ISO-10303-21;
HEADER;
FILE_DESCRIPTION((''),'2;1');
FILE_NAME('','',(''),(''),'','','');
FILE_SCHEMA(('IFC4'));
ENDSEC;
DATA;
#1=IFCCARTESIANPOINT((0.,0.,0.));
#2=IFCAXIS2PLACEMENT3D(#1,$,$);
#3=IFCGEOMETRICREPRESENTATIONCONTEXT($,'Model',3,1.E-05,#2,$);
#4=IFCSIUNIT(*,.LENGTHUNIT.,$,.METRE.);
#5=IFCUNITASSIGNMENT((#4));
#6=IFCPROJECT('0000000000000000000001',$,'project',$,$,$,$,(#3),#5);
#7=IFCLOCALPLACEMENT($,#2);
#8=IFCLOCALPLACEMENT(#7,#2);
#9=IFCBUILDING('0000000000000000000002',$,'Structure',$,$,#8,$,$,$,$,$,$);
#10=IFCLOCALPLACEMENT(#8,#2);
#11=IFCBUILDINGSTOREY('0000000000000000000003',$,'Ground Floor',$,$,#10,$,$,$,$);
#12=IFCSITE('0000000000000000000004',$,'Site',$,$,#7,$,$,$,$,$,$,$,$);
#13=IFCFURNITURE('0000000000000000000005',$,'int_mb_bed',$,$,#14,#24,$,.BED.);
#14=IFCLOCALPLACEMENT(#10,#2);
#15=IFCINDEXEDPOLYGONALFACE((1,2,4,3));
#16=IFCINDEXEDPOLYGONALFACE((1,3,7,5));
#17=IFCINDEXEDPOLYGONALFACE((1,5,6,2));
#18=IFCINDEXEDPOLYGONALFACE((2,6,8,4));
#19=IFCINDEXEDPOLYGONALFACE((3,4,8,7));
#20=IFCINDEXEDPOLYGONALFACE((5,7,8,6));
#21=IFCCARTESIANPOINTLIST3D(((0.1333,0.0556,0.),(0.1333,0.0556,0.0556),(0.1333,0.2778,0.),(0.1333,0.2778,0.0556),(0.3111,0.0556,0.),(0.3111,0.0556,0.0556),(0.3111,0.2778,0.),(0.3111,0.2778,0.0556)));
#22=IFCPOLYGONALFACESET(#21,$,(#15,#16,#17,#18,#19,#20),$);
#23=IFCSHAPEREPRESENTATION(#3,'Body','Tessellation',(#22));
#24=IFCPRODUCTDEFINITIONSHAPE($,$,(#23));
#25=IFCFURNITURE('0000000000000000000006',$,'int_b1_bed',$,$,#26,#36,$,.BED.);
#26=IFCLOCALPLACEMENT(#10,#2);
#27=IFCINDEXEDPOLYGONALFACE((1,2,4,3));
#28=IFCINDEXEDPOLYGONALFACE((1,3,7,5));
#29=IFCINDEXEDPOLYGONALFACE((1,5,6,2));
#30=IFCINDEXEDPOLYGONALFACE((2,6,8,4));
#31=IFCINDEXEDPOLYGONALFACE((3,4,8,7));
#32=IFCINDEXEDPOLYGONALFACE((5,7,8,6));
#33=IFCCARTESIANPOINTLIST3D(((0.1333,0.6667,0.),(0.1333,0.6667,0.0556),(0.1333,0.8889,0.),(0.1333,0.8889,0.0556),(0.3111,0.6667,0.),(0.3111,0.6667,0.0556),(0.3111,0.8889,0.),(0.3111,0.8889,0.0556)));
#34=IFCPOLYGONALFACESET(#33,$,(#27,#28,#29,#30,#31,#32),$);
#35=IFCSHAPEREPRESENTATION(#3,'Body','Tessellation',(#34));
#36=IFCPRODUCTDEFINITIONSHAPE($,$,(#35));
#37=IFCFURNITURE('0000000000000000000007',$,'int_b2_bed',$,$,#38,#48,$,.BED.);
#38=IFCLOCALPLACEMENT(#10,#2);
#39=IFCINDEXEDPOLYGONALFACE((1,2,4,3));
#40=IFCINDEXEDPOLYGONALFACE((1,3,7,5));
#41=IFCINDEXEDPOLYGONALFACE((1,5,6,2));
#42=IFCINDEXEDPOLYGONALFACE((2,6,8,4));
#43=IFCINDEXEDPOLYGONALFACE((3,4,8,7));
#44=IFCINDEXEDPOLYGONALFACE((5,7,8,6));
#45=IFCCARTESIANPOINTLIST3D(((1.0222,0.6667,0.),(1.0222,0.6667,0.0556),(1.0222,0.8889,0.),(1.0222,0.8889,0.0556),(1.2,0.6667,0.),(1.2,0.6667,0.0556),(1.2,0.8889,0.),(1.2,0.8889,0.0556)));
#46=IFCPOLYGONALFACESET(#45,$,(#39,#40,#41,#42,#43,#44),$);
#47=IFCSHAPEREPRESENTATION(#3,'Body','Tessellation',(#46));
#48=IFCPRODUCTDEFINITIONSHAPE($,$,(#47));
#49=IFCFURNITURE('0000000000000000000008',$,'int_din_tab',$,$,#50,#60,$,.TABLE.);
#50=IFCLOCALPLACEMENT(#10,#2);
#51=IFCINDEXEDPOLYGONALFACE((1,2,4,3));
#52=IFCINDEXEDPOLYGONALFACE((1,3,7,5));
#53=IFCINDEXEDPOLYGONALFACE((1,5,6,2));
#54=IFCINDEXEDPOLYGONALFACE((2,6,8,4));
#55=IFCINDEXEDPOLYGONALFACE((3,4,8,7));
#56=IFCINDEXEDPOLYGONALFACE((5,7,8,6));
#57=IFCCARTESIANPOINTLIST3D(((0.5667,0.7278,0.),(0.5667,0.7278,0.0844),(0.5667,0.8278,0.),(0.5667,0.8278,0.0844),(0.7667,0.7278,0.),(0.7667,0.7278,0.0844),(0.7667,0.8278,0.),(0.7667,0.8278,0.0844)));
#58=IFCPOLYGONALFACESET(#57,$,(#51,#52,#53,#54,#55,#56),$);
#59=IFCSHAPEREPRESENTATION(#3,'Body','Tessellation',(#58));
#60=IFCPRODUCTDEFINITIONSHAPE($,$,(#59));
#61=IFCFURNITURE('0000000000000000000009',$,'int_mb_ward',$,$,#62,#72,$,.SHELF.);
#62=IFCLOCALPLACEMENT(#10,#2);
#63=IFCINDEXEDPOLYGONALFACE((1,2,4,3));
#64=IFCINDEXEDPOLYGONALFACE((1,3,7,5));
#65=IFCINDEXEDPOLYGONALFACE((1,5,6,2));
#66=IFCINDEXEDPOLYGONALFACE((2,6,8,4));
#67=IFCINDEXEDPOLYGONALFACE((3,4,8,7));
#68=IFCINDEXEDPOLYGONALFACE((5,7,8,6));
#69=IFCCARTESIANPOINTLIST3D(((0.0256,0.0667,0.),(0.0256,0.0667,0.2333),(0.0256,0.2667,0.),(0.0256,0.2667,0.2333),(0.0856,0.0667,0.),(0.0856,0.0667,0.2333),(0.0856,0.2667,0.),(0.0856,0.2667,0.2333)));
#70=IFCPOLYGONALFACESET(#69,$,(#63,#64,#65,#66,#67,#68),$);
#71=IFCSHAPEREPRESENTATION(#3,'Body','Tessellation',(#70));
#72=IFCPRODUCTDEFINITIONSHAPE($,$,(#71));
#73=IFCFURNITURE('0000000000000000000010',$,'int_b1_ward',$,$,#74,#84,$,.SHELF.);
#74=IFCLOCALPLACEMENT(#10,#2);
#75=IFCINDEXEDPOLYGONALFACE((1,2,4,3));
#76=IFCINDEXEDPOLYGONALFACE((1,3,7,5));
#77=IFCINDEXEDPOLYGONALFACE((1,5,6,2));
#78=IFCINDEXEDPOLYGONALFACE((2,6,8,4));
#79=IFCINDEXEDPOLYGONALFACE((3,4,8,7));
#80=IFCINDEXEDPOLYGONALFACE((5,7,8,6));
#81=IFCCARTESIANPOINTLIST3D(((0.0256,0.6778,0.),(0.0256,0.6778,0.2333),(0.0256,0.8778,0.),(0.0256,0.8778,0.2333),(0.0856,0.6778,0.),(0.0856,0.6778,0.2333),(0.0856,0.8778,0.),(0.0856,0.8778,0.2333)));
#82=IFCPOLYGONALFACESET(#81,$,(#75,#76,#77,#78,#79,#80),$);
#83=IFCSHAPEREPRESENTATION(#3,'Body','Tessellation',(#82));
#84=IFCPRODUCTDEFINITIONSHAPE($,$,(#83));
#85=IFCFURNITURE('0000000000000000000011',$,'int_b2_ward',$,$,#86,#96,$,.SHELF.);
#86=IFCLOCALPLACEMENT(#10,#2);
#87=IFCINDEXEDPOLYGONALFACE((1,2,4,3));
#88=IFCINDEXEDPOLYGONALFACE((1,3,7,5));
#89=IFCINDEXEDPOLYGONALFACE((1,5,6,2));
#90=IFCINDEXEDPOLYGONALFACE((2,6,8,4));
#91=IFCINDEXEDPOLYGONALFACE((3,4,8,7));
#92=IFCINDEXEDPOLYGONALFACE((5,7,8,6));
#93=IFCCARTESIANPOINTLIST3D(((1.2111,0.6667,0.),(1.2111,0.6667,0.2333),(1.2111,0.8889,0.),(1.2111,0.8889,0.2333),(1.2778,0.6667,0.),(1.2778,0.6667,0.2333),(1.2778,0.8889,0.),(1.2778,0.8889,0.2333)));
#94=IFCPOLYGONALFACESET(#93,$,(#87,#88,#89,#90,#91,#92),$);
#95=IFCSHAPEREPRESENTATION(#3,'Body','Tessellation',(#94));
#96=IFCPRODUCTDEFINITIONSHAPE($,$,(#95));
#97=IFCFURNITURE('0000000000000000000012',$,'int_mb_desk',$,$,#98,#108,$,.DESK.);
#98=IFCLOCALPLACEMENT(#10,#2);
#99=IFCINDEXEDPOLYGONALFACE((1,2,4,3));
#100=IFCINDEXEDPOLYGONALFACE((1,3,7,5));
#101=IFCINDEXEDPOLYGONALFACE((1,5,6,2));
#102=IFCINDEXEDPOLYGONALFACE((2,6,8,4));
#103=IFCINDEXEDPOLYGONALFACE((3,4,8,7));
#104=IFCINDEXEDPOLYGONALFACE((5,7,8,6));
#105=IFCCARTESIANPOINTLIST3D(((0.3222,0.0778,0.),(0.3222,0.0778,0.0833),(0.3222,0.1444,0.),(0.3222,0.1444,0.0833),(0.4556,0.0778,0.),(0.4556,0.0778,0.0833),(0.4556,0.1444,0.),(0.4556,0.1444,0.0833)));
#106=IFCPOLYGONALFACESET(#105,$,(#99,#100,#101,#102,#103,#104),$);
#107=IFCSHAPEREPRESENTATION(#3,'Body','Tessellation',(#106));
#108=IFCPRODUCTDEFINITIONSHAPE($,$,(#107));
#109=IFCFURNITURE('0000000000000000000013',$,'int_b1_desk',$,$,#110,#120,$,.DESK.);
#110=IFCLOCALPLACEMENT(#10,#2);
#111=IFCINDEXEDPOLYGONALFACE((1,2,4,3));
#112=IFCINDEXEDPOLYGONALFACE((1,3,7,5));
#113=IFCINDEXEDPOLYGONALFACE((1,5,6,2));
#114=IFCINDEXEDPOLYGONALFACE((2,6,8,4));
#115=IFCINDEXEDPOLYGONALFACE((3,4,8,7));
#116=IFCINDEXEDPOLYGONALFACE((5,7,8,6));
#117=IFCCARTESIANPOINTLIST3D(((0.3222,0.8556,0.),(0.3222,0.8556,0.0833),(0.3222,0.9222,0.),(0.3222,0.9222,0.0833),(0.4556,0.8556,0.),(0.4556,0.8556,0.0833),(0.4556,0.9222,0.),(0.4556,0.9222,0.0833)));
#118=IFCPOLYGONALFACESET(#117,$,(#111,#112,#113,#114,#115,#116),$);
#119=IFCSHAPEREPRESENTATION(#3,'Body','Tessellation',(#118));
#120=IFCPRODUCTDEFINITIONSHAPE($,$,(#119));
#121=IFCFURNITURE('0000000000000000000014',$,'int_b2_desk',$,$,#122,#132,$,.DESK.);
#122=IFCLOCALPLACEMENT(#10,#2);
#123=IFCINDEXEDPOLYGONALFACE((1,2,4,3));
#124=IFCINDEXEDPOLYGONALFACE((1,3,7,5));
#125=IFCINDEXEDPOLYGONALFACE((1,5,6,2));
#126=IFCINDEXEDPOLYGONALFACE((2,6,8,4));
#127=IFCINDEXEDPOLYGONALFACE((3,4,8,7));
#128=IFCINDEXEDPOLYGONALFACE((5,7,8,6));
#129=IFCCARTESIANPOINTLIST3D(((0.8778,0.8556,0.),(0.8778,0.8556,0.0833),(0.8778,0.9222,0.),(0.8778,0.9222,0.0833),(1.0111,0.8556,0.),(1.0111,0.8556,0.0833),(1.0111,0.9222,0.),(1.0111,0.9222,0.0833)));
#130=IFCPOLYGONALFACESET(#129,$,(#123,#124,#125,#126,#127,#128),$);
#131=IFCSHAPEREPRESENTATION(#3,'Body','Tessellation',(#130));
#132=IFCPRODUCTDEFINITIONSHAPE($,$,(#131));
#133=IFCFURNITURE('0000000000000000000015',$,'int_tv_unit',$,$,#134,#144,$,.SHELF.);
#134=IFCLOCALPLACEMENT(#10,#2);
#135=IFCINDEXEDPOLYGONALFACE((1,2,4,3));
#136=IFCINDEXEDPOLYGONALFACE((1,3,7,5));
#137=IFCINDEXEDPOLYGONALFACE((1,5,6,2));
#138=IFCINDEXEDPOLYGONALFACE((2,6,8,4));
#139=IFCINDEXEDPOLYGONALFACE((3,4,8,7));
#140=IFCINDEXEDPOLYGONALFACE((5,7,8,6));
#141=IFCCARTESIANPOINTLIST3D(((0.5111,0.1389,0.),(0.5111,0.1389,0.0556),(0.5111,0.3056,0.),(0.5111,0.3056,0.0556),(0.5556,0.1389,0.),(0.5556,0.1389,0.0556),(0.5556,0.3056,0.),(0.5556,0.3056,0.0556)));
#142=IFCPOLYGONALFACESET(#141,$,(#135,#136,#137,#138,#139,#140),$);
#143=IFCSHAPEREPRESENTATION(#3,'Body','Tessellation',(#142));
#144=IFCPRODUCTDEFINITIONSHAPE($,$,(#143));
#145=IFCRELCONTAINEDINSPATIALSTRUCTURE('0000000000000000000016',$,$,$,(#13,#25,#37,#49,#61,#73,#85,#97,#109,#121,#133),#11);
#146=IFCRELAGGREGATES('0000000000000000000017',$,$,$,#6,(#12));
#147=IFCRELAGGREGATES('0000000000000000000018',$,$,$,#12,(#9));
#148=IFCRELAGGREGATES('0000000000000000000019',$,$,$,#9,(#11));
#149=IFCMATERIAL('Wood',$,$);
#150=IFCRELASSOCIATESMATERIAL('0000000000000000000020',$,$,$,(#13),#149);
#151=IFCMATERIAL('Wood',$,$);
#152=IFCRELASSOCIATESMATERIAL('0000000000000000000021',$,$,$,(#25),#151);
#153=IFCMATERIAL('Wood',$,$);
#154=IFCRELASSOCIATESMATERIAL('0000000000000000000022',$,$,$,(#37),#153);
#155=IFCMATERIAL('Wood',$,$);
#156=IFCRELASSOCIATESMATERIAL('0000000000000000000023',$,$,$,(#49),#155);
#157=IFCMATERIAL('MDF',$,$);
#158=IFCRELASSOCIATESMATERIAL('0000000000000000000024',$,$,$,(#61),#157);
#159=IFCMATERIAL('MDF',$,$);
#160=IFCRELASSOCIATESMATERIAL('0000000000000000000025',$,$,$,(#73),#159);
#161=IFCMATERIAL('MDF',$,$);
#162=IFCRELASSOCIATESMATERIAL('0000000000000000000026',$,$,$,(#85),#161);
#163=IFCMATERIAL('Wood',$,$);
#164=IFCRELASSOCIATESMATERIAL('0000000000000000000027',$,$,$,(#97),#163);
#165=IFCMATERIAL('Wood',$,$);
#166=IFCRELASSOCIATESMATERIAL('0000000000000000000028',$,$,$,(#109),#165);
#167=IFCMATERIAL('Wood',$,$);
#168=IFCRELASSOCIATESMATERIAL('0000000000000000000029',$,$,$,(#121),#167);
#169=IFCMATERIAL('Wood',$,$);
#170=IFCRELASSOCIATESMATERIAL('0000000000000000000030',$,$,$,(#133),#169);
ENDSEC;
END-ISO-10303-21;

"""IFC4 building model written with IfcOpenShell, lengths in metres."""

from ifc_helpers import new_model, si_unit, frame, origin, place, context, project, spatial, polyline, outline, extrude, material, element, save


model = new_model("IFC4")

# Units and contexts
model_context = context("Model", 3, precision=1e-05, world=origin())
ifc_project = project(units=[si_unit("LENGTHUNIT", "METRE")], contexts=[model_context])

# Site, building, storey
site_placement = place(None, origin())
site = spatial("IfcSite", under=ifc_project, at=site_placement, Name="Site")
building_placement = place(site_placement, origin())
building = spatial("IfcBuilding", under=site, at=building_placement, Name="Structure")
storey_placement = place(building_placement, origin())
storey = spatial("IfcBuildingStorey", under=building, at=storey_placement, Name="Ground Floor")

# Furniture
ifc_material_1 = material(Name="Wood")
furniture_1_placement = place(storey_placement, frame((0.2222, 0.1667, 0.0)))
element("IfcFurniture", 1, at=furniture_1_placement, inside=storey, material=ifc_material_1, Name="int_mb_bed", PredefinedType="BED", context=model_context, shape_type="SweptSolid", body=[
    extrude(outline(polyline([(-0.0889, -0.1111), (0.0889, -0.1111), (0.0889, 0.1111), (-0.0889, 0.1111), (-0.0889, -0.1111)])), origin(), (0.0, 0.0, 1.0), 0.0556),
])
ifc_material_2 = material(Name="Wood")
furniture_2_placement = place(storey_placement, frame((0.2222, 0.7778, 0.0)))
element("IfcFurniture", 2, at=furniture_2_placement, inside=storey, material=ifc_material_2, Name="int_b1_bed", PredefinedType="BED", context=model_context, shape_type="SweptSolid", body=[
    extrude(outline(polyline([(-0.0889, -0.1111), (0.0889, -0.1111), (0.0889, 0.1111), (-0.0889, 0.1111), (-0.0889, -0.1111)])), origin(), (0.0, 0.0, 1.0), 0.0556),
])
ifc_material_3 = material(Name="Wood")
furniture_3_placement = place(storey_placement, frame((1.1111, 0.7778, 0.0)))
element("IfcFurniture", 3, at=furniture_3_placement, inside=storey, material=ifc_material_3, Name="int_b2_bed", PredefinedType="BED", context=model_context, shape_type="SweptSolid", body=[
    extrude(outline(polyline([(-0.0889, -0.1111), (0.0889, -0.1111), (0.0889, 0.1111), (-0.0889, 0.1111), (-0.0889, -0.1111)])), origin(), (0.0, 0.0, 1.0), 0.0556),
])
ifc_material_4 = material(Name="Wood")
furniture_4_placement = place(storey_placement, frame((0.6667, 0.7778, 0.0)))
element("IfcFurniture", 4, at=furniture_4_placement, inside=storey, material=ifc_material_4, Name="int_din_tab", PredefinedType="TABLE", context=model_context, shape_type="SweptSolid", body=[
    extrude(outline(polyline([(-0.1, -0.05), (0.1, -0.05), (0.1, 0.05), (-0.1, 0.05), (-0.1, -0.05)])), origin(), (0.0, 0.0, 1.0), 0.0844),
])
ifc_material_5 = material(Name="MDF")
furniture_5_placement = place(storey_placement, frame((0.0556, 0.1667, 0.0)))
element("IfcFurniture", 5, at=furniture_5_placement, inside=storey, material=ifc_material_5, Name="int_mb_ward", PredefinedType="SHELF", context=model_context, shape_type="SweptSolid", body=[
    extrude(outline(polyline([(-0.03, -0.1), (0.03, -0.1), (0.03, 0.1), (-0.03, 0.1), (-0.03, -0.1)])), origin(), (0.0, 0.0, 1.0), 0.2333),
])
ifc_material_6 = material(Name="MDF")
furniture_6_placement = place(storey_placement, frame((0.0556, 0.7778, 0.0)))
element("IfcFurniture", 6, at=furniture_6_placement, inside=storey, material=ifc_material_6, Name="int_b1_ward", PredefinedType="SHELF", context=model_context, shape_type="SweptSolid", body=[
    extrude(outline(polyline([(-0.03, -0.1), (0.03, -0.1), (0.03, 0.1), (-0.03, 0.1), (-0.03, -0.1)])), origin(), (0.0, 0.0, 1.0), 0.2333),
])
ifc_material_7 = material(Name="MDF")
furniture_7_placement = place(storey_placement, frame((1.2444, 0.7778, 0.0)))
element("IfcFurniture", 7, at=furniture_7_placement, inside=storey, material=ifc_material_7, Name="int_b2_ward", PredefinedType="SHELF", context=model_context, shape_type="SweptSolid", body=[
    extrude(outline(polyline([(-0.0333, -0.1111), (0.0333, -0.1111), (0.0333, 0.1111), (-0.0333, 0.1111), (-0.0333, -0.1111)])), origin(), (0.0, 0.0, 1.0), 0.2333),
])
ifc_material_8 = material(Name="Wood")
furniture_8_placement = place(storey_placement, frame((0.3889, 0.1111, 0.0)))
element("IfcFurniture", 8, at=furniture_8_placement, inside=storey, material=ifc_material_8, Name="int_mb_desk", PredefinedType="DESK", context=model_context, shape_type="SweptSolid", body=[
    extrude(outline(polyline([(-0.0667, -0.0333), (0.0667, -0.0333), (0.0667, 0.0333), (-0.0667, 0.0333), (-0.0667, -0.0333)])), origin(), (0.0, 0.0, 1.0), 0.0833),
])
ifc_material_9 = material(Name="Wood")
furniture_9_placement = place(storey_placement, frame((0.3889, 0.8889, 0.0)))
element("IfcFurniture", 9, at=furniture_9_placement, inside=storey, material=ifc_material_9, Name="int_b1_desk", PredefinedType="DESK", context=model_context, shape_type="SweptSolid", body=[
    extrude(outline(polyline([(-0.0667, -0.0333), (0.0667, -0.0333), (0.0667, 0.0333), (-0.0667, 0.0333), (-0.0667, -0.0333)])), origin(), (0.0, 0.0, 1.0), 0.0833),
])
ifc_material_10 = material(Name="Wood")
furniture_10_placement = place(storey_placement, frame((0.9444, 0.8889, 0.0)))
element("IfcFurniture", 10, at=furniture_10_placement, inside=storey, material=ifc_material_10, Name="int_b2_desk", PredefinedType="DESK", context=model_context, shape_type="SweptSolid", body=[
    extrude(outline(polyline([(-0.0667, -0.0333), (0.0667, -0.0333), (0.0667, 0.0333), (-0.0667, 0.0333), (-0.0667, -0.0333)])), origin(), (0.0, 0.0, 1.0), 0.0833),
])
ifc_material_11 = material(Name="Wood")
furniture_11_placement = place(storey_placement, frame((0.5333, 0.2222, 0.0)))
element("IfcFurniture", 11, at=furniture_11_placement, inside=storey, material=ifc_material_11, Name="int_tv_unit", PredefinedType="SHELF", context=model_context, shape_type="SweptSolid", body=[
    extrude(outline(polyline([(-0.0222, -0.0833), (0.0222, -0.0833), (0.0222, 0.0833), (-0.0222, 0.0833), (-0.0222, -0.0833)])), origin(), (0.0, 0.0, 1.0), 0.0556),
])

save(model, "model.ifc")
